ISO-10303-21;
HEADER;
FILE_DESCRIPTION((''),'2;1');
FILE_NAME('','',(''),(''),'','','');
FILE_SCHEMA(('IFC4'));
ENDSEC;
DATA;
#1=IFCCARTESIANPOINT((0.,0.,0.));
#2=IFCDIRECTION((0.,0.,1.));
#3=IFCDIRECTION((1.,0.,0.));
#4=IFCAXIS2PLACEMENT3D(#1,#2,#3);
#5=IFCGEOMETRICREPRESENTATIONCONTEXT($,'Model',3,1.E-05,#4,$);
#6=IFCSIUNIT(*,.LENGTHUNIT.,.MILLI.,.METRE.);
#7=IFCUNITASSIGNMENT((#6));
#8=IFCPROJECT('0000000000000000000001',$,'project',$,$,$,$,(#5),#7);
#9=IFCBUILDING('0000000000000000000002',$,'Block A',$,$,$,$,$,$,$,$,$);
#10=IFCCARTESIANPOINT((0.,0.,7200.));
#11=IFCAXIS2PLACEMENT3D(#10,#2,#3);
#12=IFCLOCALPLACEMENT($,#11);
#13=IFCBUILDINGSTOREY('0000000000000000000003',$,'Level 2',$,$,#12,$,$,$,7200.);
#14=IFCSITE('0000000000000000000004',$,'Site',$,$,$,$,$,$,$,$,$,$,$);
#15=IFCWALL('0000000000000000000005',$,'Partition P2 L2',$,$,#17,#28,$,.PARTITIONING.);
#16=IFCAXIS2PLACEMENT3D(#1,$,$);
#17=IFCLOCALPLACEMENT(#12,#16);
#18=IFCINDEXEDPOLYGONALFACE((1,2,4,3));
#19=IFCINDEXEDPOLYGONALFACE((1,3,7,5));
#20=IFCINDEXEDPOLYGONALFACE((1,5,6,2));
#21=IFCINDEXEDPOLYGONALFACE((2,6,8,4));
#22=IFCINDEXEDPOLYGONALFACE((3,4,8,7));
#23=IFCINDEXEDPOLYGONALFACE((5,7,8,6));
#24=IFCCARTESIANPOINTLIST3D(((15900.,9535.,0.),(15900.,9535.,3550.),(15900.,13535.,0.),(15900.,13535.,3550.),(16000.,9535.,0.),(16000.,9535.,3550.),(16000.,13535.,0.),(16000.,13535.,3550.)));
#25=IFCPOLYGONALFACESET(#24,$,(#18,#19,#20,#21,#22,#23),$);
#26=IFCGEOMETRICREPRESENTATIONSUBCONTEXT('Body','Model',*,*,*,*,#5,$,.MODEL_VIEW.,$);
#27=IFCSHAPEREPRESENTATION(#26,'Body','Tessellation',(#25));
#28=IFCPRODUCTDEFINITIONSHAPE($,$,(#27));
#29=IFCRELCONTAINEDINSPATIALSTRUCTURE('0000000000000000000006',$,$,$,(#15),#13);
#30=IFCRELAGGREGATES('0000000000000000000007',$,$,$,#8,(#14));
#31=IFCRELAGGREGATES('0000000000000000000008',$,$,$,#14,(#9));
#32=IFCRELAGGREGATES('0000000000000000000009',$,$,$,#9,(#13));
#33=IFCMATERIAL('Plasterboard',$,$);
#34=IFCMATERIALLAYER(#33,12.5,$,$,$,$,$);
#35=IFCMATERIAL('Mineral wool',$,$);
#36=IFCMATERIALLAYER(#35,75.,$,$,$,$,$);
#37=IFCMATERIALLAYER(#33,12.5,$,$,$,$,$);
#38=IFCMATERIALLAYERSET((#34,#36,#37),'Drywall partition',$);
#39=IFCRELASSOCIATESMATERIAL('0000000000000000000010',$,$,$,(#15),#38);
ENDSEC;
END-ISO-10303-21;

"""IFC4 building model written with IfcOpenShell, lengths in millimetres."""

from ifc_helpers import new_model, si_unit, frame, origin_with_axes, place, context, subcontext, project, spatial, indexed_curve, outline, extrude, material, layer, layer_set, layer_usage, element, save


model = new_model("IFC4")

# Units and contexts
model_context = context("Model", 3, precision=1e-05, world=origin_with_axes())
body_context = subcontext(model_context, "Body", "Model", "MODEL_VIEW")
ifc_project = project(units=[si_unit("LENGTHUNIT", "METRE", prefix="MILLI")], contexts=[model_context])

# Site, building, storey
site = spatial("IfcSite", under=ifc_project, Name="Site")
building = spatial("IfcBuilding", under=site, Name="Block A")
storey_placement = place(None, frame((0.0, 0.0, 7200.0), z_axis=(0.0, 0.0, 1.0), x_axis=(1.0, 0.0, 0.0)))
storey = spatial("IfcBuildingStorey", under=building, at=storey_placement, Name="Level 2", Elevation=7200.0)

# Shared definitions
ifc_material_1 = material(Name="Mineral wool")

# Wall
ifc_material_2 = material(Name="Plasterboard")
ifc_layer_1 = layer(ifc_material_2, 12.5)
ifc_layer_2 = layer(ifc_material_1, 75.0)
ifc_layer_3 = layer(ifc_material_2, 12.5)
ifc_layer_set_1 = layer_set([ifc_layer_1, ifc_layer_2, ifc_layer_3], Name="Drywall partition")
ifc_layer_usage_1 = layer_usage(ifc_layer_set_1, "AXIS2", "POSITIVE", 0.0)
wall_1_placement = place(storey_placement, frame((16000.0, 9535.0, 0.0), z_axis=(0.0, 0.0, 1.0), x_axis=(0.0, 1.0, 0.0)))
element("IfcWall", 1, at=wall_1_placement, inside=storey, material=ifc_layer_usage_1, Name="Partition P2 L2", PredefinedType="PARTITIONING", context=body_context, shape_type="SweptSolid", body=[
    extrude(outline(indexed_curve([(0.0, 0.0), (0.0, 100.0), (4000.0, 100.0), (4000.0, 0.0), (0.0, 0.0)], self_intersect=False)), origin_with_axes(), (0.0, 0.0, 1.0), 3550.0),
])

save(model, "model.ifc")
